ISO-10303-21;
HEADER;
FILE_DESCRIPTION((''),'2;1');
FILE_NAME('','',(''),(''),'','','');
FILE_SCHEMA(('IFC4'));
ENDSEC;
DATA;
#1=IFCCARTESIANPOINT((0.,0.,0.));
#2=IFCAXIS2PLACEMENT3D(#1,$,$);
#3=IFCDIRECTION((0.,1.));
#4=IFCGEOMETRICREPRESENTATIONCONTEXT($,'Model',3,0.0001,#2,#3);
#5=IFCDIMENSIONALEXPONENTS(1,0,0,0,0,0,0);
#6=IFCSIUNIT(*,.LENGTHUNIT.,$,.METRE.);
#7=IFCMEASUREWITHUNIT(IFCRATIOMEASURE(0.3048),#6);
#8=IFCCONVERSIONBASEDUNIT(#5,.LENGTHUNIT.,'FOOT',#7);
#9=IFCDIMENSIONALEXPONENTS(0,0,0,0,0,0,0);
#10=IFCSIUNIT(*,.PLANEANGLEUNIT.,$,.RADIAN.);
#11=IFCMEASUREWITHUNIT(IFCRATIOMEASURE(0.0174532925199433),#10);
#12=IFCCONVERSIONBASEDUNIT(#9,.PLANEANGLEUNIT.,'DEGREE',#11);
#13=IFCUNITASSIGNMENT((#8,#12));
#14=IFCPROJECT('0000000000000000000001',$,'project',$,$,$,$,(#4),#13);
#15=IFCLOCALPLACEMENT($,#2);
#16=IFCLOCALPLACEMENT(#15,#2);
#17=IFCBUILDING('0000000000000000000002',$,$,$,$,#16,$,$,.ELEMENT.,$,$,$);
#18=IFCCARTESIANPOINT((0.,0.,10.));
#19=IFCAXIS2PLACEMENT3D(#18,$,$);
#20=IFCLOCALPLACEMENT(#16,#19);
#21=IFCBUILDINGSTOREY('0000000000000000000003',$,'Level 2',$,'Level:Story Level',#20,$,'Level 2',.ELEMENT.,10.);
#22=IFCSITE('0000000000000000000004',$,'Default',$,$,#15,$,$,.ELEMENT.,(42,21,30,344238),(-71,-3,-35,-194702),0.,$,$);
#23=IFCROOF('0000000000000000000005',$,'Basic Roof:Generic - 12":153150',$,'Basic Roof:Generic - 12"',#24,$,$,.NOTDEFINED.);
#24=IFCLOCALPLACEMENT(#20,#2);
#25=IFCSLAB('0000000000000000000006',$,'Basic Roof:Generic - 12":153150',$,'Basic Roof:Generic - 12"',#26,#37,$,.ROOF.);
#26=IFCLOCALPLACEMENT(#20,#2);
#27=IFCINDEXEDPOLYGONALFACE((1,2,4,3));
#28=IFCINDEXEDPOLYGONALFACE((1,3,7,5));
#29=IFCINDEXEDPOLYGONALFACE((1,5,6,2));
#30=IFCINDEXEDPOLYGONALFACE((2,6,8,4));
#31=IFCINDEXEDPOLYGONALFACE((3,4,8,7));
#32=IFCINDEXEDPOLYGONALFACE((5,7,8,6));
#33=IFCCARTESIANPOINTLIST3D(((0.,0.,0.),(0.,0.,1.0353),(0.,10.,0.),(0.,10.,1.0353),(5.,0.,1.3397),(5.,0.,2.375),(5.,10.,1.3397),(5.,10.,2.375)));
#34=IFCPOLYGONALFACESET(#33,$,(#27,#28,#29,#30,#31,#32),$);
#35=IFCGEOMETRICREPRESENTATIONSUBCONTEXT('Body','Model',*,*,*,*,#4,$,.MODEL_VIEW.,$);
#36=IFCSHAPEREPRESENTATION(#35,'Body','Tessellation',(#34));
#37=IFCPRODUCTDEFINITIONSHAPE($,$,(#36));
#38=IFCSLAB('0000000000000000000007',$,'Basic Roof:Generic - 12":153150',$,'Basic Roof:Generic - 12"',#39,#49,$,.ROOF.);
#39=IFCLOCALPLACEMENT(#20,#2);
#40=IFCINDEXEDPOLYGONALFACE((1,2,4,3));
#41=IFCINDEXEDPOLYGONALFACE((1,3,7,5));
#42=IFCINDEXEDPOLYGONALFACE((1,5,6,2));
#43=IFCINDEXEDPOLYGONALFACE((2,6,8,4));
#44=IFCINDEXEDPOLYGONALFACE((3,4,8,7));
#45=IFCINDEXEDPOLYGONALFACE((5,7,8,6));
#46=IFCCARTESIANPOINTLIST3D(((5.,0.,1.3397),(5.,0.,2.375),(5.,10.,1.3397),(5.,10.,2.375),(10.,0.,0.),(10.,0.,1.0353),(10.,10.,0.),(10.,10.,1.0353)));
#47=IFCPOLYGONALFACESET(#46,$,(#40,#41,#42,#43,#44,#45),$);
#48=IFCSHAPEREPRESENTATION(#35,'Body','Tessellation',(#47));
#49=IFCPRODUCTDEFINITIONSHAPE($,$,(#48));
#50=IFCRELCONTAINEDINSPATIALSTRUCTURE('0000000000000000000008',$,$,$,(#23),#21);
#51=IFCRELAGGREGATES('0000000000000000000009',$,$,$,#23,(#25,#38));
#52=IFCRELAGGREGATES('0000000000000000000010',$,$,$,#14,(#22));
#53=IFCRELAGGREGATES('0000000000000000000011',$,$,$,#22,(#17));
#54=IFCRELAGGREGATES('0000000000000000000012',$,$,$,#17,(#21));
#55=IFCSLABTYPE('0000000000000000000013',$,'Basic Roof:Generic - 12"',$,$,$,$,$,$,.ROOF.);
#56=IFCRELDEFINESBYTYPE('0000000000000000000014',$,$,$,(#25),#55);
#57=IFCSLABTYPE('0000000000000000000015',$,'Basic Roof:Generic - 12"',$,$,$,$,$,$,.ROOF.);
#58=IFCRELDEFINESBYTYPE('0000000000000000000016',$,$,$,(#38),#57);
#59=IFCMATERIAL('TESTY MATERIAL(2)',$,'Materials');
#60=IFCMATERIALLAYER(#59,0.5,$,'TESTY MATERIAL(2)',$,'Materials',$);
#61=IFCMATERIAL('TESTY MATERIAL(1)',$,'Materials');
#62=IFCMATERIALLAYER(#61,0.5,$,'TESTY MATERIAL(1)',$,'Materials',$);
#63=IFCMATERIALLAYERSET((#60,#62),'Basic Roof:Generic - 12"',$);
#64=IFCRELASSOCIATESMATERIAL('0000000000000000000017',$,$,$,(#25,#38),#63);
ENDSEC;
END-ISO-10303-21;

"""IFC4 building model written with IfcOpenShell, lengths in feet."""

from ifc_helpers import new_model, entity, si_unit, converted_unit, direction, frame, frame_2d, origin, place, context, subcontext, project, spatial, rectangle, extrude, material, layer, layer_set, type_object, element, aggregate, save


model = new_model("IFC4")

# Units and contexts
model_context = context("Model", 3, precision=0.0001, world=origin(), true_north=direction((0.0, 1.0)))
body_context = subcontext(model_context, "Body", "Model", "MODEL_VIEW")
ifc_project = project(units=[converted_unit("LENGTHUNIT", "FOOT", entity("IfcRatioMeasure", 0.3048), si_unit("LENGTHUNIT", "METRE"), dimensions=[1, 0, 0, 0, 0, 0, 0]), converted_unit("PLANEANGLEUNIT", "DEGREE", entity("IfcRatioMeasure", 0.0174532925199433), si_unit("PLANEANGLEUNIT", "RADIAN"), dimensions=[0, 0, 0, 0, 0, 0, 0])], contexts=[model_context])

# Site, building, storey
site_placement = place(None, origin())
site = spatial("IfcSite", under=ifc_project, at=site_placement, Name="Default", CompositionType="ELEMENT", RefLatitude=(42, 21, 30, 344238), RefLongitude=(-71, -3, -35, -194702), RefElevation=0.0)
building_placement = place(site_placement, origin())
building = spatial("IfcBuilding", under=site, at=building_placement, CompositionType="ELEMENT")
storey_placement = place(building_placement, frame((0.0, 0.0, 10.0)))
storey = spatial("IfcBuildingStorey", under=building, at=storey_placement, Name="Level 2", ObjectType="Level:Story Level", LongName="Level 2", CompositionType="ELEMENT", Elevation=10.0)

# Roof, slabs
roof_placement = place(storey_placement, origin())
roof = element("IfcRoof", 1, at=roof_placement, inside=storey, Name="Basic Roof:Generic - 12\":153150", ObjectType="Basic Roof:Generic - 12\"", PredefinedType="NOTDEFINED")
ifc_material_1 = material(Name="TESTY MATERIAL(2)", Category="Materials")
ifc_layer_1 = layer(ifc_material_1, 0.5, Name="TESTY MATERIAL(2)", Category="Materials")
ifc_material_2 = material(Name="TESTY MATERIAL(1)", Category="Materials")
ifc_layer_2 = layer(ifc_material_2, 0.5, Name="TESTY MATERIAL(1)", Category="Materials")
ifc_layer_set = layer_set([ifc_layer_1, ifc_layer_2], Name="Basic Roof:Generic - 12\"")
slab_type_1 = type_object("IfcSlabType", Name="Basic Roof:Generic - 12\"", PredefinedType="ROOF")
slab_1_placement = place(roof_placement, origin())
slab_1 = element("IfcSlab", 2, at=slab_1_placement, type_object=slab_type_1, material=ifc_layer_set, Name="Basic Roof:Generic - 12\":153150", ObjectType="Basic Roof:Generic - 12\"", PredefinedType="ROOF", context=body_context, shape_type="SweptSolid", body=[
    extrude(rectangle(XDim=5.1764, YDim=10.0, at=frame_2d((0.0, 0.0), x_axis=(-1.0, 0.0))), frame((2.5, 5.0, 0.6699), z_axis=(-0.258819, 0.0, 0.965926), x_axis=(0.965926, 0.0, 0.258819)), (0.258819, 0.0, 0.965926), 1.0353),
])
slab_type_2 = type_object("IfcSlabType", Name="Basic Roof:Generic - 12\"", PredefinedType="ROOF")
slab_2_placement = place(roof_placement, origin())
slab_2 = element("IfcSlab", 3, at=slab_2_placement, type_object=slab_type_2, material=ifc_layer_set, Name="Basic Roof:Generic - 12\":153150", ObjectType="Basic Roof:Generic - 12\"", PredefinedType="ROOF", context=body_context, shape_type="SweptSolid", body=[
    extrude(rectangle(XDim=10.0, YDim=5.1764, at=frame_2d((0.0, 0.0), x_axis=(0.0, -1.0))), frame((7.5, 5.0, 0.6699), z_axis=(0.258819, 0.0, 0.965926), x_axis=(0.965926, 0.0, -0.258819)), (-0.258819, 0.0, 0.965926), 1.0353),
])
aggregate(roof, [slab_1, slab_2])

save(model, "model.ifc")
